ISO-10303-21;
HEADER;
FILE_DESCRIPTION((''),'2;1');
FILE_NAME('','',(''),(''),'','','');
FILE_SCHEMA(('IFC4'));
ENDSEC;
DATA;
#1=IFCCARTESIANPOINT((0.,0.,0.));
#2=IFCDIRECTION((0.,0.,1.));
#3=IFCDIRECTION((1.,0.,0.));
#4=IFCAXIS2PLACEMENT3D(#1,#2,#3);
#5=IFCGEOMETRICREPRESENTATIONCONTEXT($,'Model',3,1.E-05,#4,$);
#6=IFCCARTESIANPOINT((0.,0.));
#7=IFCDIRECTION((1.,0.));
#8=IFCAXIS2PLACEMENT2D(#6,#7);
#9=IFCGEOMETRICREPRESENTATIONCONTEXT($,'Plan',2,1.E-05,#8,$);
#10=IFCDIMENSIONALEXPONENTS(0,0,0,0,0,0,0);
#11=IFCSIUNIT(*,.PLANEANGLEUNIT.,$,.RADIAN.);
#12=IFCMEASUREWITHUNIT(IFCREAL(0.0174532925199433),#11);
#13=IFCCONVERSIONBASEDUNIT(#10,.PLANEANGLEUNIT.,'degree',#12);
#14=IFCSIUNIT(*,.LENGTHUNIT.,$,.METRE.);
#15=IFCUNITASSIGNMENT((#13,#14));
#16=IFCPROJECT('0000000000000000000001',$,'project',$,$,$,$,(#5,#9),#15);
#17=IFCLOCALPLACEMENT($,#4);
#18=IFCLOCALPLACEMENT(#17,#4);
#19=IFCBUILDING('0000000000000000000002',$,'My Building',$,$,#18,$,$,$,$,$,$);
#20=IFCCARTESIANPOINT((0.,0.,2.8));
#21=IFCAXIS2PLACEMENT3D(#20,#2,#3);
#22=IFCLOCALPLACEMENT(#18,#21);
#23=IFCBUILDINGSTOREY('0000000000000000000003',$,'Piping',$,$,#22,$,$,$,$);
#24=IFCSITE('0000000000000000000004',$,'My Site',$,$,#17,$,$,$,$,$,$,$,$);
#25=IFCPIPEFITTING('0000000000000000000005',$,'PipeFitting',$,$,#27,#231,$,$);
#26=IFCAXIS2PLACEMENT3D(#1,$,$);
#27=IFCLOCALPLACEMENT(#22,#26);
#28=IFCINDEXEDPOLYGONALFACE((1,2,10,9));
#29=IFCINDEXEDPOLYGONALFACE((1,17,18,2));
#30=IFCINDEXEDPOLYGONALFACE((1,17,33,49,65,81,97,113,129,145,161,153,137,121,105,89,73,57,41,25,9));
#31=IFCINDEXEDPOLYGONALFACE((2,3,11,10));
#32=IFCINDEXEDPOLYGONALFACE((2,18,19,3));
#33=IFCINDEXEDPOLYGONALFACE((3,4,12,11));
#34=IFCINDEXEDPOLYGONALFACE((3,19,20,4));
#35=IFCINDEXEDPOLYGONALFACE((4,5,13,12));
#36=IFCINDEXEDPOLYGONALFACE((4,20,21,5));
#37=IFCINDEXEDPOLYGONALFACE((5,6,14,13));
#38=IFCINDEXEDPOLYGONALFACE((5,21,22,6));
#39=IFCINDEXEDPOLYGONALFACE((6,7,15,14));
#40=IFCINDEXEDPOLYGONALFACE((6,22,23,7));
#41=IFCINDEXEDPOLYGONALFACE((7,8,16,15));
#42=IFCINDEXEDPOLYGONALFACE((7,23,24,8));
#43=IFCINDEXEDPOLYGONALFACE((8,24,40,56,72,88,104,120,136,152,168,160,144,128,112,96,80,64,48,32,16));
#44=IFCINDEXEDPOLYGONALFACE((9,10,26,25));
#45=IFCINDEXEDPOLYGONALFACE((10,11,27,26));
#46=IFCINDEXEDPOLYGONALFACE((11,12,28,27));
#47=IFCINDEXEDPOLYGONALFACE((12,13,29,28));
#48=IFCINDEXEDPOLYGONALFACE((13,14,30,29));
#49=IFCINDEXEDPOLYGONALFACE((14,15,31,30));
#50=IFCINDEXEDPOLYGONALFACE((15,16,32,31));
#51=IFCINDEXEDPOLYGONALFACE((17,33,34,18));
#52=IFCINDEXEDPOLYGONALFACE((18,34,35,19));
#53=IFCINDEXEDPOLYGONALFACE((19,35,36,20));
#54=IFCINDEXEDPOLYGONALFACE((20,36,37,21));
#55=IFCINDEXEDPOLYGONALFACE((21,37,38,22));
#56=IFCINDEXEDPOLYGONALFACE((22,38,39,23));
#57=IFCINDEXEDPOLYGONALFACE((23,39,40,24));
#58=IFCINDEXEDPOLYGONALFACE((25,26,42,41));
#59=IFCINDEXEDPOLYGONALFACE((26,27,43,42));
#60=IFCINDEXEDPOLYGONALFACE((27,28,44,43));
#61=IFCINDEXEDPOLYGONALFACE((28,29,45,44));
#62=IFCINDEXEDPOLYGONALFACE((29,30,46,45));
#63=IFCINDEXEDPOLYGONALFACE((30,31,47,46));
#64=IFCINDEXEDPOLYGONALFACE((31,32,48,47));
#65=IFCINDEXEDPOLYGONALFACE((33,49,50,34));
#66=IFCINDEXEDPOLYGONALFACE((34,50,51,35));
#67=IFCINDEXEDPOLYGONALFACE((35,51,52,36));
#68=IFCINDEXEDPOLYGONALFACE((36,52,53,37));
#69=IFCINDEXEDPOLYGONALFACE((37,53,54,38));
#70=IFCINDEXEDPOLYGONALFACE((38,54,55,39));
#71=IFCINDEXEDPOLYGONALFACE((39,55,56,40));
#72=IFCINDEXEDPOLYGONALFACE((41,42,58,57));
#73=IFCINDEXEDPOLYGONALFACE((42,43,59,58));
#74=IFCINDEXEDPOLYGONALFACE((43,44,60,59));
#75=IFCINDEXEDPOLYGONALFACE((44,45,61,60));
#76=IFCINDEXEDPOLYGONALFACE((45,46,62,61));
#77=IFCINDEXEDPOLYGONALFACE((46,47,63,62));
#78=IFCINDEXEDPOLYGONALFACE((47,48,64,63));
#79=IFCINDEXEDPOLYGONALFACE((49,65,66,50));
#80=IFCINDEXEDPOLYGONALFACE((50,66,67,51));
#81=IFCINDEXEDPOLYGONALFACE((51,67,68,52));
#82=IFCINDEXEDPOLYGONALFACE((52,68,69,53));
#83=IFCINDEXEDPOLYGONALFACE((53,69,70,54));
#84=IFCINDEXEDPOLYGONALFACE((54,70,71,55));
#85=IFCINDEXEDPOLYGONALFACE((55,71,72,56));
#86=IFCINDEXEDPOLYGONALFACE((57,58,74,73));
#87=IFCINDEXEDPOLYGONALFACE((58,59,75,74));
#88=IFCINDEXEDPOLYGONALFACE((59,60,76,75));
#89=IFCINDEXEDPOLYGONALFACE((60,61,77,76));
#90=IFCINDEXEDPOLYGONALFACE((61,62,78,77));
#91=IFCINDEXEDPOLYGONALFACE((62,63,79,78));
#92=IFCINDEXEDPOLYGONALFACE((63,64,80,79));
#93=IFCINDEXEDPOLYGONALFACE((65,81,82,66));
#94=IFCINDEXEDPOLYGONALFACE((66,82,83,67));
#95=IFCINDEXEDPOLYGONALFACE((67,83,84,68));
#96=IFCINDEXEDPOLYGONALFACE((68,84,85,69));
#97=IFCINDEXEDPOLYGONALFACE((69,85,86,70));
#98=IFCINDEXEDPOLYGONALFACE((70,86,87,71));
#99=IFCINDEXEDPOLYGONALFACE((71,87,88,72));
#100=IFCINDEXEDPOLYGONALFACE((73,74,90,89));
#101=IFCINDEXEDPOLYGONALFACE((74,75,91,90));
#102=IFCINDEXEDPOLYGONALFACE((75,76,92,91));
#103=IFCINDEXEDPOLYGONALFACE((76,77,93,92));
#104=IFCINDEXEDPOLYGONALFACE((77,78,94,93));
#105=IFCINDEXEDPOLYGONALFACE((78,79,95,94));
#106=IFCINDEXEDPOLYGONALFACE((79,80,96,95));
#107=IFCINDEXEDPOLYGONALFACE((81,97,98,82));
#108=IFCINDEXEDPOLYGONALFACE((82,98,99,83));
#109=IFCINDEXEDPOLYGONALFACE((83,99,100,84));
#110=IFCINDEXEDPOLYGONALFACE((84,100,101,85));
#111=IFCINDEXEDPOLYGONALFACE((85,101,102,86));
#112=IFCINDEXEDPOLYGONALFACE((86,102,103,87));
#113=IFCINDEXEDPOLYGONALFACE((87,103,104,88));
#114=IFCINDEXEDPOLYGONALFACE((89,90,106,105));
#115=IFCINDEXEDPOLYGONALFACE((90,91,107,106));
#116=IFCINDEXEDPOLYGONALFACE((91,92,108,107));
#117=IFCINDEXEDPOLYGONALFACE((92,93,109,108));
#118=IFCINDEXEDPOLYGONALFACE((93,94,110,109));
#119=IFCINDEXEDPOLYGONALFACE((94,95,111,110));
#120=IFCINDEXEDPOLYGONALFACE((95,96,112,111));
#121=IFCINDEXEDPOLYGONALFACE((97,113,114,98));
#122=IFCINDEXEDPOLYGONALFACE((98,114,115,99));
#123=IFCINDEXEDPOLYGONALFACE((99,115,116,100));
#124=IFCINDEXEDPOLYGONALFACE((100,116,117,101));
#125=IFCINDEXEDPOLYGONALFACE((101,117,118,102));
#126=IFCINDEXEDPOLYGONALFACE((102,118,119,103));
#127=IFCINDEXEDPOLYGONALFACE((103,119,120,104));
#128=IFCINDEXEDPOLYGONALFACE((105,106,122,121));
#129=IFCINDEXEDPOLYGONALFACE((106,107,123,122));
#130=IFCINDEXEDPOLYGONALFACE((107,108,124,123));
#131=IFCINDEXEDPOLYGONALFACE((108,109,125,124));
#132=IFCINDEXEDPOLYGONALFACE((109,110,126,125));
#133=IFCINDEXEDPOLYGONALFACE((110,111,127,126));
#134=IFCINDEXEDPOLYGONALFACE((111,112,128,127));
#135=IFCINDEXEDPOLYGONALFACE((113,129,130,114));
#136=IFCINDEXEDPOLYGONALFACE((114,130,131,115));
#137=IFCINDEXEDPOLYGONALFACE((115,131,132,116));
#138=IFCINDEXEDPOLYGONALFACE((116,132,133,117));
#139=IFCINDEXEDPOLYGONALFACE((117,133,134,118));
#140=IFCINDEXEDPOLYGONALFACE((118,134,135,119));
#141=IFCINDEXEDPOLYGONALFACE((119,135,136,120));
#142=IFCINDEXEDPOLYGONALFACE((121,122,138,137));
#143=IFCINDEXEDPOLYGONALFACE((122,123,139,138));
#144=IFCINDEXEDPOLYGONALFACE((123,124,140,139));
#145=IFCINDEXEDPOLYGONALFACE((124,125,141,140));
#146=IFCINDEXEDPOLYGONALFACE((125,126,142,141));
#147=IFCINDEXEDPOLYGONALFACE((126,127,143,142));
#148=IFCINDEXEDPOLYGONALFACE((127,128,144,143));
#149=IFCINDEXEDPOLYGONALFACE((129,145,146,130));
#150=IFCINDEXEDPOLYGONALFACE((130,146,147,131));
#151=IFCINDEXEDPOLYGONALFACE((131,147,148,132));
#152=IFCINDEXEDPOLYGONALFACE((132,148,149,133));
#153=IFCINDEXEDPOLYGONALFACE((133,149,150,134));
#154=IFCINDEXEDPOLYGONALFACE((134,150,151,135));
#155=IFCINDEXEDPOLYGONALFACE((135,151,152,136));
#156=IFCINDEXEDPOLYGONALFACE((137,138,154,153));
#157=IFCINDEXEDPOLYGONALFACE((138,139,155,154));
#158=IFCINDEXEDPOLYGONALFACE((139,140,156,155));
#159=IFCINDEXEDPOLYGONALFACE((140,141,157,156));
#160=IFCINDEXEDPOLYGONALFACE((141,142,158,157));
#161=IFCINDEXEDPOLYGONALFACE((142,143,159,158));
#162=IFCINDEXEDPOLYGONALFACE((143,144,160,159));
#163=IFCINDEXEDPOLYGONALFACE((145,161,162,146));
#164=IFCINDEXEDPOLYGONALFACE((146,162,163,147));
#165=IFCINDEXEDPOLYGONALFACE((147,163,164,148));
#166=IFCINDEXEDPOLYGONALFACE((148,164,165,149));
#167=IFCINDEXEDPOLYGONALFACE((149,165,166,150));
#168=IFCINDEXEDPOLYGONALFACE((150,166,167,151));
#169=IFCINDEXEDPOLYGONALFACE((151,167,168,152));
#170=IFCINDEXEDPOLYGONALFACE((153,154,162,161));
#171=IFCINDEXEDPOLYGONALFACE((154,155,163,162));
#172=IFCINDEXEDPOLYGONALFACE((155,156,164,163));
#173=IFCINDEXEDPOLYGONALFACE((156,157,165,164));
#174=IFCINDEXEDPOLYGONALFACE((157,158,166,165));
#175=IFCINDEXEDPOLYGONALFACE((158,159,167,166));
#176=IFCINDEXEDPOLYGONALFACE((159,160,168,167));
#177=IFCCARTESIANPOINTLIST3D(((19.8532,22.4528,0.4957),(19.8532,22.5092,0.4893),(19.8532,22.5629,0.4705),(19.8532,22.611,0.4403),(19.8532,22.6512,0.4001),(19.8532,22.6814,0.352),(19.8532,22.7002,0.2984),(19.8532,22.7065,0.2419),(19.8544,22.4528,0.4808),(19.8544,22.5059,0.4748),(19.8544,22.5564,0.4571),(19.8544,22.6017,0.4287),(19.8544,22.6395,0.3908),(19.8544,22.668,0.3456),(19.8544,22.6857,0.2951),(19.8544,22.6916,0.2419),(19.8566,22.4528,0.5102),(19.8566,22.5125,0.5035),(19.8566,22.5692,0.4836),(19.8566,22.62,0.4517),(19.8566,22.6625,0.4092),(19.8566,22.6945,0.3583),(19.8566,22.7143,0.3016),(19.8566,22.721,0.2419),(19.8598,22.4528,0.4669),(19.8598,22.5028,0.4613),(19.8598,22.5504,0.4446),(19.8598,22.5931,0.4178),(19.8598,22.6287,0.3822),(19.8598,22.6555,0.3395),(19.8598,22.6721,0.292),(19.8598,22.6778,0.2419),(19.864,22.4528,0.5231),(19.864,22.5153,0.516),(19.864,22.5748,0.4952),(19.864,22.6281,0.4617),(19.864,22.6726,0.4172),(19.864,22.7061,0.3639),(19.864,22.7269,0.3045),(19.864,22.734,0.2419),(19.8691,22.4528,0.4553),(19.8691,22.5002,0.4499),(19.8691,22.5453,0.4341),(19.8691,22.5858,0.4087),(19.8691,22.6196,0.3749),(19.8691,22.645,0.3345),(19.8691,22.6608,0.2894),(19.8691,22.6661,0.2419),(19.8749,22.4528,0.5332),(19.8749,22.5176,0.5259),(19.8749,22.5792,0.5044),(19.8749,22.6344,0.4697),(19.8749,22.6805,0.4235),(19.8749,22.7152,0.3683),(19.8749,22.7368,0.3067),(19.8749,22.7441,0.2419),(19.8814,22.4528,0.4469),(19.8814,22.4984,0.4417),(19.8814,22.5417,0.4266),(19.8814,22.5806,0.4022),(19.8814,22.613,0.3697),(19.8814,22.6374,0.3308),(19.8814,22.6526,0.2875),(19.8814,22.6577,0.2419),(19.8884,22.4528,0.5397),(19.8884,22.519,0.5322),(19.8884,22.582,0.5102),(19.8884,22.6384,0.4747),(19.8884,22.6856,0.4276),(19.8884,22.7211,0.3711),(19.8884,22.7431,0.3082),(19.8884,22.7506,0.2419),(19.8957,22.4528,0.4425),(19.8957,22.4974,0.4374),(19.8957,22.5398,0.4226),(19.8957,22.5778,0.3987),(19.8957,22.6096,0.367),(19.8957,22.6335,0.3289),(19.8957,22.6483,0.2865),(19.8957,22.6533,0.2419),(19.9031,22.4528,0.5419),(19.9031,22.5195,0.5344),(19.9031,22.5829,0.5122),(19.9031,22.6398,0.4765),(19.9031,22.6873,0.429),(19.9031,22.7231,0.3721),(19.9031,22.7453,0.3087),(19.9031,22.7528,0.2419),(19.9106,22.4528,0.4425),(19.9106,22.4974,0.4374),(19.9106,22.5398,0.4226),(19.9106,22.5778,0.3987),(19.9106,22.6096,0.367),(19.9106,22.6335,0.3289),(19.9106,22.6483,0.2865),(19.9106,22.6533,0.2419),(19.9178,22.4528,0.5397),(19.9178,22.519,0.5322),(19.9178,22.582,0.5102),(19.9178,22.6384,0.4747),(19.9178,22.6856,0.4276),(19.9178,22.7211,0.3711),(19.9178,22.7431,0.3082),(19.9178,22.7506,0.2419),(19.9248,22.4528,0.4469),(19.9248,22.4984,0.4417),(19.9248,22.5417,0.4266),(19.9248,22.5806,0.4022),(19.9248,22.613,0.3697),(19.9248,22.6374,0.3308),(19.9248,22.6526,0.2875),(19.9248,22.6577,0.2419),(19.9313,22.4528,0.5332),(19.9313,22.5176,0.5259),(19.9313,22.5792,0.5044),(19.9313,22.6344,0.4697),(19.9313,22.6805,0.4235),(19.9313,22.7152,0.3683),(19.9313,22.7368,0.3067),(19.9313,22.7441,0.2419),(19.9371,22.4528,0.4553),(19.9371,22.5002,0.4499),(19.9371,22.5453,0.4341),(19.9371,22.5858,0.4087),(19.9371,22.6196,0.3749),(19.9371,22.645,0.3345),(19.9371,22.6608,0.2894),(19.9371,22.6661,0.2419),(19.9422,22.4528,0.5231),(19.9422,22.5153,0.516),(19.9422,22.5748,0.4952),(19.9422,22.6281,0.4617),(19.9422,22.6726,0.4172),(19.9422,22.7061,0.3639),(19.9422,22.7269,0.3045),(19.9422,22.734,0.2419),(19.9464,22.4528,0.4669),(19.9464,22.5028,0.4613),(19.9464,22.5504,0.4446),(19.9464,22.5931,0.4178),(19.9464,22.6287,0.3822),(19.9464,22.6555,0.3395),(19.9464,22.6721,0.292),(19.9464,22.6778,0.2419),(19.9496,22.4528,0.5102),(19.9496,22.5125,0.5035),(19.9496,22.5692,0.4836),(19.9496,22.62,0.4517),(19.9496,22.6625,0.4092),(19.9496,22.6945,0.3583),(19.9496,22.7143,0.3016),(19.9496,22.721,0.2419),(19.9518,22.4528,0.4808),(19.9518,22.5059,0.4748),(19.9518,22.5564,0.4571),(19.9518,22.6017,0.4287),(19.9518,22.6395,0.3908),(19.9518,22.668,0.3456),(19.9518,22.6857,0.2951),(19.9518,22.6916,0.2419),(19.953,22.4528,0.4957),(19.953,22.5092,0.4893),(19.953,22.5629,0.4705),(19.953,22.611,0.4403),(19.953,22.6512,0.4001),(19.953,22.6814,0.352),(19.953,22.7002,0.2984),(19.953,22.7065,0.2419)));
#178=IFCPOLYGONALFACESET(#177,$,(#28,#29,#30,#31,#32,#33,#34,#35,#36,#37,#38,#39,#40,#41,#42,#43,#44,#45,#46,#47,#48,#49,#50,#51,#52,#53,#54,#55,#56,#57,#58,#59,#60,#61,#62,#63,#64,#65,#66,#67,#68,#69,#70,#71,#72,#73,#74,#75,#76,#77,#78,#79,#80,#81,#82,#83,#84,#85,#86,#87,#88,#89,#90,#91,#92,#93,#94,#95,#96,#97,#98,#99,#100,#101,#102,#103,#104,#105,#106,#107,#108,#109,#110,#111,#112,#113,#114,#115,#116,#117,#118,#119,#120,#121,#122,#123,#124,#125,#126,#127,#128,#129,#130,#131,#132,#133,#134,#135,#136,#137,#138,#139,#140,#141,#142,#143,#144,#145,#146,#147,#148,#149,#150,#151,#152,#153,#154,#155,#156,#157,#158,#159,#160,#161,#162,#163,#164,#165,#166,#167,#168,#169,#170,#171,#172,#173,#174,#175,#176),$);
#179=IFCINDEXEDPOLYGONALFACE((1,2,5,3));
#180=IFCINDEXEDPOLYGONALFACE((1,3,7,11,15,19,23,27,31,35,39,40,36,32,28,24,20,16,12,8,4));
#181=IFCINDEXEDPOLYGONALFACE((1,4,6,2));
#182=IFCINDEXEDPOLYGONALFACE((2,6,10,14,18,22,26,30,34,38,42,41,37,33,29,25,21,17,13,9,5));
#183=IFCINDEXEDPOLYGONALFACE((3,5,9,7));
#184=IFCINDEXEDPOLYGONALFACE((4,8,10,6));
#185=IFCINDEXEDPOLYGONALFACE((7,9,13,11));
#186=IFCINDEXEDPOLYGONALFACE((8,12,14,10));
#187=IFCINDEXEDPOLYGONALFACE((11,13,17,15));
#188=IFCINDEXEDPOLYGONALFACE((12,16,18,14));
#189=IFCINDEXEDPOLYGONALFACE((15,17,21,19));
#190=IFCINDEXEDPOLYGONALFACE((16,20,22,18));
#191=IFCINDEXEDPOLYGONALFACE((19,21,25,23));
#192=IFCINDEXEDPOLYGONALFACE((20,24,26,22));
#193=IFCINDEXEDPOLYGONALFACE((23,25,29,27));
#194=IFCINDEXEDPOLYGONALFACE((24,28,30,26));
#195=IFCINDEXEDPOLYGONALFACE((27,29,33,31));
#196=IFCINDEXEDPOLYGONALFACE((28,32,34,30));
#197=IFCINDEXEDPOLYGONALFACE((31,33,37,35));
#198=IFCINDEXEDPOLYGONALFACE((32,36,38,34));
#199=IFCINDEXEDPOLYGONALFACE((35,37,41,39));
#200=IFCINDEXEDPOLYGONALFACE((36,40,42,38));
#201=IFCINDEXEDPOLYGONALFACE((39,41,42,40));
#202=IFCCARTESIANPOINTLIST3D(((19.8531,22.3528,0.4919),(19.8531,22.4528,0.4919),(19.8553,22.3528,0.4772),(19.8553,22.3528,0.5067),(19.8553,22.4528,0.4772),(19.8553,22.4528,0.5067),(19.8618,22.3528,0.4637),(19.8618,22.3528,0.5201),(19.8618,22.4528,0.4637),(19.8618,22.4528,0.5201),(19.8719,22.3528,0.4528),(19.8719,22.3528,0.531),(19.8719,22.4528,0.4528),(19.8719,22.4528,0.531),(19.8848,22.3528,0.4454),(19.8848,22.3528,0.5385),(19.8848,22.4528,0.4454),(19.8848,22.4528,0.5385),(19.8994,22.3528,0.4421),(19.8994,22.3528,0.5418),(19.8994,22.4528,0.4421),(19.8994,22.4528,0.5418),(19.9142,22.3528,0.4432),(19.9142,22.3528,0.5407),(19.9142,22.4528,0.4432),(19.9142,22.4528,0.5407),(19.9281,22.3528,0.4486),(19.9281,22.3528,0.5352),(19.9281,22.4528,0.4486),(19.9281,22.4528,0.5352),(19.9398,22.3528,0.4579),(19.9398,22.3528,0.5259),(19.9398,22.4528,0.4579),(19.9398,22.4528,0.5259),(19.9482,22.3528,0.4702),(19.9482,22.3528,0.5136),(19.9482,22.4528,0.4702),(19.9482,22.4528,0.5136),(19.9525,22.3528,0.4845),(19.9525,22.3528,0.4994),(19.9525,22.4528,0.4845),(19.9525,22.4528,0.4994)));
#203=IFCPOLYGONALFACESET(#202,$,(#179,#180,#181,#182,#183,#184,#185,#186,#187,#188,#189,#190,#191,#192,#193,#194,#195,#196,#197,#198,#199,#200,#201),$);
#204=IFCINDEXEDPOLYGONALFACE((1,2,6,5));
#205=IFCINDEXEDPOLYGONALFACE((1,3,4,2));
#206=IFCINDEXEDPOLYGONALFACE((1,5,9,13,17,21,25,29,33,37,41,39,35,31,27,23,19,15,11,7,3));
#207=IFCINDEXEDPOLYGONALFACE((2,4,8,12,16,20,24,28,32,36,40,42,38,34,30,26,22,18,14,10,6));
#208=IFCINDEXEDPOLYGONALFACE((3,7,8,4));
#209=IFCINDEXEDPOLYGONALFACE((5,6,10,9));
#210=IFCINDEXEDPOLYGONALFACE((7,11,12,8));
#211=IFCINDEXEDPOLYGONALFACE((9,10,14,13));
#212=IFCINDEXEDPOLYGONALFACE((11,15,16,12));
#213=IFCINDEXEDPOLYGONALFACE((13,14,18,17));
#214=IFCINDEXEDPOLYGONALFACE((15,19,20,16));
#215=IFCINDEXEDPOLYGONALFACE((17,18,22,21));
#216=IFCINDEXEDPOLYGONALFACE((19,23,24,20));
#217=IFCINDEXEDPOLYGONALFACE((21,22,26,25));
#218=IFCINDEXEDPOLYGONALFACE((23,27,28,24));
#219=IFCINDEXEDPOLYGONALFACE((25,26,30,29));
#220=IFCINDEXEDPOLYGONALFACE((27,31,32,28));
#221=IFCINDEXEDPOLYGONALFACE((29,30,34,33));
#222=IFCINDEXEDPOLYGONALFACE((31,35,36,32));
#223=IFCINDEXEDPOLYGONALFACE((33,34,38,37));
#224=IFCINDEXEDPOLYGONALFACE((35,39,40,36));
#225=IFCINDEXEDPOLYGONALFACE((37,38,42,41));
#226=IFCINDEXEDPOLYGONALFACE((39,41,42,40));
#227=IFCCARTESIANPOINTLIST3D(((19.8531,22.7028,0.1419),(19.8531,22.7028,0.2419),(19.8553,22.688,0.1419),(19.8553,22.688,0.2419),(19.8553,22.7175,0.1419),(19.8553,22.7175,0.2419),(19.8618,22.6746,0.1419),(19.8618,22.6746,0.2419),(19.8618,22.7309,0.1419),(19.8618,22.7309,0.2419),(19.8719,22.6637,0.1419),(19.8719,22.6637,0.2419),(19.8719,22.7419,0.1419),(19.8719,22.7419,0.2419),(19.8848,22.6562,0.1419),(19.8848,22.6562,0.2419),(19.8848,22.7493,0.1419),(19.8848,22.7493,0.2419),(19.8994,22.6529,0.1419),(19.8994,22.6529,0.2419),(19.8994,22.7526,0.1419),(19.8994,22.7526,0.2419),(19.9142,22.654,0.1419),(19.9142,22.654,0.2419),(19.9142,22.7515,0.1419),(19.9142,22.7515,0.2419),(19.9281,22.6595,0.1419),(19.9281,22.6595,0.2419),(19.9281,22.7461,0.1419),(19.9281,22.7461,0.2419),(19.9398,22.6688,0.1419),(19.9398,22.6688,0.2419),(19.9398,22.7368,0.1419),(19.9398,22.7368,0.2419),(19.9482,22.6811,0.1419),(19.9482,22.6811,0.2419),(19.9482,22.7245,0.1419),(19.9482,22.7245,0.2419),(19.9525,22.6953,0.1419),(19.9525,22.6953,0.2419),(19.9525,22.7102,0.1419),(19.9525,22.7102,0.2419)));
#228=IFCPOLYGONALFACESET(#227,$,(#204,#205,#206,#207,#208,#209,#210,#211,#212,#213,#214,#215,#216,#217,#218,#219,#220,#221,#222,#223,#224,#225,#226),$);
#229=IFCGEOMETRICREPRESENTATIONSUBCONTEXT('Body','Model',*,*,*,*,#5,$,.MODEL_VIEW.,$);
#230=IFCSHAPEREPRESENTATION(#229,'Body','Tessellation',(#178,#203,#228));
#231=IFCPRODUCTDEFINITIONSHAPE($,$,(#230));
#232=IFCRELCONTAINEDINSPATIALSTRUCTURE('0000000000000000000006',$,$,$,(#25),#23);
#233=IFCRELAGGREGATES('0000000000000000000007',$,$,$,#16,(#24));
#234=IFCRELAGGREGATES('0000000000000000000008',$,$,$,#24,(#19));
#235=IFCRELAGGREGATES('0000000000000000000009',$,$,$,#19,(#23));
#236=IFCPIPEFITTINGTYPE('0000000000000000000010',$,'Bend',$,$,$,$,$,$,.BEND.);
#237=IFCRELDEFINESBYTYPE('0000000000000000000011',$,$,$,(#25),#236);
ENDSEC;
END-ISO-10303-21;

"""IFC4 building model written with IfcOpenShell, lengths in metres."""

from ifc_helpers import new_model, entity, si_unit, converted_unit, frame, origin_with_axes, origin_2d_with_axis, place, context, subcontext, project, spatial, circle, extrude, source, transform, mapped, type_object, type_shapes, element, save


model = new_model("IFC4")

# Units and contexts
model_context = context("Model", 3, precision=1e-05, world=origin_with_axes())
plan_context = context("Plan", 2, precision=1e-05, world=origin_2d_with_axis())
body_context = subcontext(model_context, "Body", "Model", "MODEL_VIEW")
ifc_project = project(units=[converted_unit("PLANEANGLEUNIT", "degree", entity("IfcReal", 0.0174532925199433), si_unit("PLANEANGLEUNIT", "RADIAN"), dimensions=[0, 0, 0, 0, 0, 0, 0]), si_unit("LENGTHUNIT", "METRE")], contexts=[model_context, plan_context])

# Site, building, storey
site_placement = place(None, origin_with_axes())
site = spatial("IfcSite", under=ifc_project, at=site_placement, Name="My Site")
building_placement = place(site_placement, origin_with_axes())
building = spatial("IfcBuilding", under=site, at=building_placement, Name="My Building")
storey_placement = place(building_placement, frame((0.0, 0.0, 2.8), z_axis=(0.0, 0.0, 1.0), x_axis=(1.0, 0.0, 0.0)))
storey = spatial("IfcBuildingStorey", under=building, at=storey_placement, Name="Piping")

# Pipe fitting
pipe_fitting_type_1 = type_object("IfcPipeFittingType", Name="Bend", PredefinedType="BEND")
shared_shape_1 = source(origin_with_axes(), body_context, "Body", "SolidModel", [
    entity("IfcSweptDiskSolid", entity("IfcIndexedPolyCurve", entity("IfcCartesianPointList3D", [[0.0, 0.0, 0.1], [0.0, -0.0732, 0.2768], [0.0, -0.25, 0.35]]), [entity("IfcArcIndex", [1, 2, 3])]), 0.05),
    extrude(circle(Radius=0.05), origin_with_axes(), (0.0, 0.0, 1.0), 0.1),
    extrude(circle(Radius=0.05), frame((0.0, -0.25, 0.35), z_axis=(0.0, -1.0, 0.0), x_axis=(1.0, 0.0, 0.0)), (0.0, 0.0, 1.0), 0.1),
])
type_shapes(pipe_fitting_type_1, [shared_shape_1])
for number, where, z_axis, x_axis, name in (
    (1, (19.9031, 22.3528, 0.4919), (0.0, 1.0, 0.0), (-1.0, 0.0, 0.0), "PipeFitting"),
):
    element("IfcPipeFitting", number, at=place(storey_placement, frame(where, z_axis=z_axis, x_axis=x_axis)), inside=storey, type_object=pipe_fitting_type_1, Name=name, context=body_context, shape_type="MappedRepresentation", body=[
        mapped(shared_shape_1, transform((0.0, 0.0, 0.0), x_axis=(1.0, 0.0, 0.0), y_axis=(0.0, 1.0, 0.0), z_axis=(0.0, 0.0, 1.0), scale=1.0)),
    ])

save(model, "model.ifc")
